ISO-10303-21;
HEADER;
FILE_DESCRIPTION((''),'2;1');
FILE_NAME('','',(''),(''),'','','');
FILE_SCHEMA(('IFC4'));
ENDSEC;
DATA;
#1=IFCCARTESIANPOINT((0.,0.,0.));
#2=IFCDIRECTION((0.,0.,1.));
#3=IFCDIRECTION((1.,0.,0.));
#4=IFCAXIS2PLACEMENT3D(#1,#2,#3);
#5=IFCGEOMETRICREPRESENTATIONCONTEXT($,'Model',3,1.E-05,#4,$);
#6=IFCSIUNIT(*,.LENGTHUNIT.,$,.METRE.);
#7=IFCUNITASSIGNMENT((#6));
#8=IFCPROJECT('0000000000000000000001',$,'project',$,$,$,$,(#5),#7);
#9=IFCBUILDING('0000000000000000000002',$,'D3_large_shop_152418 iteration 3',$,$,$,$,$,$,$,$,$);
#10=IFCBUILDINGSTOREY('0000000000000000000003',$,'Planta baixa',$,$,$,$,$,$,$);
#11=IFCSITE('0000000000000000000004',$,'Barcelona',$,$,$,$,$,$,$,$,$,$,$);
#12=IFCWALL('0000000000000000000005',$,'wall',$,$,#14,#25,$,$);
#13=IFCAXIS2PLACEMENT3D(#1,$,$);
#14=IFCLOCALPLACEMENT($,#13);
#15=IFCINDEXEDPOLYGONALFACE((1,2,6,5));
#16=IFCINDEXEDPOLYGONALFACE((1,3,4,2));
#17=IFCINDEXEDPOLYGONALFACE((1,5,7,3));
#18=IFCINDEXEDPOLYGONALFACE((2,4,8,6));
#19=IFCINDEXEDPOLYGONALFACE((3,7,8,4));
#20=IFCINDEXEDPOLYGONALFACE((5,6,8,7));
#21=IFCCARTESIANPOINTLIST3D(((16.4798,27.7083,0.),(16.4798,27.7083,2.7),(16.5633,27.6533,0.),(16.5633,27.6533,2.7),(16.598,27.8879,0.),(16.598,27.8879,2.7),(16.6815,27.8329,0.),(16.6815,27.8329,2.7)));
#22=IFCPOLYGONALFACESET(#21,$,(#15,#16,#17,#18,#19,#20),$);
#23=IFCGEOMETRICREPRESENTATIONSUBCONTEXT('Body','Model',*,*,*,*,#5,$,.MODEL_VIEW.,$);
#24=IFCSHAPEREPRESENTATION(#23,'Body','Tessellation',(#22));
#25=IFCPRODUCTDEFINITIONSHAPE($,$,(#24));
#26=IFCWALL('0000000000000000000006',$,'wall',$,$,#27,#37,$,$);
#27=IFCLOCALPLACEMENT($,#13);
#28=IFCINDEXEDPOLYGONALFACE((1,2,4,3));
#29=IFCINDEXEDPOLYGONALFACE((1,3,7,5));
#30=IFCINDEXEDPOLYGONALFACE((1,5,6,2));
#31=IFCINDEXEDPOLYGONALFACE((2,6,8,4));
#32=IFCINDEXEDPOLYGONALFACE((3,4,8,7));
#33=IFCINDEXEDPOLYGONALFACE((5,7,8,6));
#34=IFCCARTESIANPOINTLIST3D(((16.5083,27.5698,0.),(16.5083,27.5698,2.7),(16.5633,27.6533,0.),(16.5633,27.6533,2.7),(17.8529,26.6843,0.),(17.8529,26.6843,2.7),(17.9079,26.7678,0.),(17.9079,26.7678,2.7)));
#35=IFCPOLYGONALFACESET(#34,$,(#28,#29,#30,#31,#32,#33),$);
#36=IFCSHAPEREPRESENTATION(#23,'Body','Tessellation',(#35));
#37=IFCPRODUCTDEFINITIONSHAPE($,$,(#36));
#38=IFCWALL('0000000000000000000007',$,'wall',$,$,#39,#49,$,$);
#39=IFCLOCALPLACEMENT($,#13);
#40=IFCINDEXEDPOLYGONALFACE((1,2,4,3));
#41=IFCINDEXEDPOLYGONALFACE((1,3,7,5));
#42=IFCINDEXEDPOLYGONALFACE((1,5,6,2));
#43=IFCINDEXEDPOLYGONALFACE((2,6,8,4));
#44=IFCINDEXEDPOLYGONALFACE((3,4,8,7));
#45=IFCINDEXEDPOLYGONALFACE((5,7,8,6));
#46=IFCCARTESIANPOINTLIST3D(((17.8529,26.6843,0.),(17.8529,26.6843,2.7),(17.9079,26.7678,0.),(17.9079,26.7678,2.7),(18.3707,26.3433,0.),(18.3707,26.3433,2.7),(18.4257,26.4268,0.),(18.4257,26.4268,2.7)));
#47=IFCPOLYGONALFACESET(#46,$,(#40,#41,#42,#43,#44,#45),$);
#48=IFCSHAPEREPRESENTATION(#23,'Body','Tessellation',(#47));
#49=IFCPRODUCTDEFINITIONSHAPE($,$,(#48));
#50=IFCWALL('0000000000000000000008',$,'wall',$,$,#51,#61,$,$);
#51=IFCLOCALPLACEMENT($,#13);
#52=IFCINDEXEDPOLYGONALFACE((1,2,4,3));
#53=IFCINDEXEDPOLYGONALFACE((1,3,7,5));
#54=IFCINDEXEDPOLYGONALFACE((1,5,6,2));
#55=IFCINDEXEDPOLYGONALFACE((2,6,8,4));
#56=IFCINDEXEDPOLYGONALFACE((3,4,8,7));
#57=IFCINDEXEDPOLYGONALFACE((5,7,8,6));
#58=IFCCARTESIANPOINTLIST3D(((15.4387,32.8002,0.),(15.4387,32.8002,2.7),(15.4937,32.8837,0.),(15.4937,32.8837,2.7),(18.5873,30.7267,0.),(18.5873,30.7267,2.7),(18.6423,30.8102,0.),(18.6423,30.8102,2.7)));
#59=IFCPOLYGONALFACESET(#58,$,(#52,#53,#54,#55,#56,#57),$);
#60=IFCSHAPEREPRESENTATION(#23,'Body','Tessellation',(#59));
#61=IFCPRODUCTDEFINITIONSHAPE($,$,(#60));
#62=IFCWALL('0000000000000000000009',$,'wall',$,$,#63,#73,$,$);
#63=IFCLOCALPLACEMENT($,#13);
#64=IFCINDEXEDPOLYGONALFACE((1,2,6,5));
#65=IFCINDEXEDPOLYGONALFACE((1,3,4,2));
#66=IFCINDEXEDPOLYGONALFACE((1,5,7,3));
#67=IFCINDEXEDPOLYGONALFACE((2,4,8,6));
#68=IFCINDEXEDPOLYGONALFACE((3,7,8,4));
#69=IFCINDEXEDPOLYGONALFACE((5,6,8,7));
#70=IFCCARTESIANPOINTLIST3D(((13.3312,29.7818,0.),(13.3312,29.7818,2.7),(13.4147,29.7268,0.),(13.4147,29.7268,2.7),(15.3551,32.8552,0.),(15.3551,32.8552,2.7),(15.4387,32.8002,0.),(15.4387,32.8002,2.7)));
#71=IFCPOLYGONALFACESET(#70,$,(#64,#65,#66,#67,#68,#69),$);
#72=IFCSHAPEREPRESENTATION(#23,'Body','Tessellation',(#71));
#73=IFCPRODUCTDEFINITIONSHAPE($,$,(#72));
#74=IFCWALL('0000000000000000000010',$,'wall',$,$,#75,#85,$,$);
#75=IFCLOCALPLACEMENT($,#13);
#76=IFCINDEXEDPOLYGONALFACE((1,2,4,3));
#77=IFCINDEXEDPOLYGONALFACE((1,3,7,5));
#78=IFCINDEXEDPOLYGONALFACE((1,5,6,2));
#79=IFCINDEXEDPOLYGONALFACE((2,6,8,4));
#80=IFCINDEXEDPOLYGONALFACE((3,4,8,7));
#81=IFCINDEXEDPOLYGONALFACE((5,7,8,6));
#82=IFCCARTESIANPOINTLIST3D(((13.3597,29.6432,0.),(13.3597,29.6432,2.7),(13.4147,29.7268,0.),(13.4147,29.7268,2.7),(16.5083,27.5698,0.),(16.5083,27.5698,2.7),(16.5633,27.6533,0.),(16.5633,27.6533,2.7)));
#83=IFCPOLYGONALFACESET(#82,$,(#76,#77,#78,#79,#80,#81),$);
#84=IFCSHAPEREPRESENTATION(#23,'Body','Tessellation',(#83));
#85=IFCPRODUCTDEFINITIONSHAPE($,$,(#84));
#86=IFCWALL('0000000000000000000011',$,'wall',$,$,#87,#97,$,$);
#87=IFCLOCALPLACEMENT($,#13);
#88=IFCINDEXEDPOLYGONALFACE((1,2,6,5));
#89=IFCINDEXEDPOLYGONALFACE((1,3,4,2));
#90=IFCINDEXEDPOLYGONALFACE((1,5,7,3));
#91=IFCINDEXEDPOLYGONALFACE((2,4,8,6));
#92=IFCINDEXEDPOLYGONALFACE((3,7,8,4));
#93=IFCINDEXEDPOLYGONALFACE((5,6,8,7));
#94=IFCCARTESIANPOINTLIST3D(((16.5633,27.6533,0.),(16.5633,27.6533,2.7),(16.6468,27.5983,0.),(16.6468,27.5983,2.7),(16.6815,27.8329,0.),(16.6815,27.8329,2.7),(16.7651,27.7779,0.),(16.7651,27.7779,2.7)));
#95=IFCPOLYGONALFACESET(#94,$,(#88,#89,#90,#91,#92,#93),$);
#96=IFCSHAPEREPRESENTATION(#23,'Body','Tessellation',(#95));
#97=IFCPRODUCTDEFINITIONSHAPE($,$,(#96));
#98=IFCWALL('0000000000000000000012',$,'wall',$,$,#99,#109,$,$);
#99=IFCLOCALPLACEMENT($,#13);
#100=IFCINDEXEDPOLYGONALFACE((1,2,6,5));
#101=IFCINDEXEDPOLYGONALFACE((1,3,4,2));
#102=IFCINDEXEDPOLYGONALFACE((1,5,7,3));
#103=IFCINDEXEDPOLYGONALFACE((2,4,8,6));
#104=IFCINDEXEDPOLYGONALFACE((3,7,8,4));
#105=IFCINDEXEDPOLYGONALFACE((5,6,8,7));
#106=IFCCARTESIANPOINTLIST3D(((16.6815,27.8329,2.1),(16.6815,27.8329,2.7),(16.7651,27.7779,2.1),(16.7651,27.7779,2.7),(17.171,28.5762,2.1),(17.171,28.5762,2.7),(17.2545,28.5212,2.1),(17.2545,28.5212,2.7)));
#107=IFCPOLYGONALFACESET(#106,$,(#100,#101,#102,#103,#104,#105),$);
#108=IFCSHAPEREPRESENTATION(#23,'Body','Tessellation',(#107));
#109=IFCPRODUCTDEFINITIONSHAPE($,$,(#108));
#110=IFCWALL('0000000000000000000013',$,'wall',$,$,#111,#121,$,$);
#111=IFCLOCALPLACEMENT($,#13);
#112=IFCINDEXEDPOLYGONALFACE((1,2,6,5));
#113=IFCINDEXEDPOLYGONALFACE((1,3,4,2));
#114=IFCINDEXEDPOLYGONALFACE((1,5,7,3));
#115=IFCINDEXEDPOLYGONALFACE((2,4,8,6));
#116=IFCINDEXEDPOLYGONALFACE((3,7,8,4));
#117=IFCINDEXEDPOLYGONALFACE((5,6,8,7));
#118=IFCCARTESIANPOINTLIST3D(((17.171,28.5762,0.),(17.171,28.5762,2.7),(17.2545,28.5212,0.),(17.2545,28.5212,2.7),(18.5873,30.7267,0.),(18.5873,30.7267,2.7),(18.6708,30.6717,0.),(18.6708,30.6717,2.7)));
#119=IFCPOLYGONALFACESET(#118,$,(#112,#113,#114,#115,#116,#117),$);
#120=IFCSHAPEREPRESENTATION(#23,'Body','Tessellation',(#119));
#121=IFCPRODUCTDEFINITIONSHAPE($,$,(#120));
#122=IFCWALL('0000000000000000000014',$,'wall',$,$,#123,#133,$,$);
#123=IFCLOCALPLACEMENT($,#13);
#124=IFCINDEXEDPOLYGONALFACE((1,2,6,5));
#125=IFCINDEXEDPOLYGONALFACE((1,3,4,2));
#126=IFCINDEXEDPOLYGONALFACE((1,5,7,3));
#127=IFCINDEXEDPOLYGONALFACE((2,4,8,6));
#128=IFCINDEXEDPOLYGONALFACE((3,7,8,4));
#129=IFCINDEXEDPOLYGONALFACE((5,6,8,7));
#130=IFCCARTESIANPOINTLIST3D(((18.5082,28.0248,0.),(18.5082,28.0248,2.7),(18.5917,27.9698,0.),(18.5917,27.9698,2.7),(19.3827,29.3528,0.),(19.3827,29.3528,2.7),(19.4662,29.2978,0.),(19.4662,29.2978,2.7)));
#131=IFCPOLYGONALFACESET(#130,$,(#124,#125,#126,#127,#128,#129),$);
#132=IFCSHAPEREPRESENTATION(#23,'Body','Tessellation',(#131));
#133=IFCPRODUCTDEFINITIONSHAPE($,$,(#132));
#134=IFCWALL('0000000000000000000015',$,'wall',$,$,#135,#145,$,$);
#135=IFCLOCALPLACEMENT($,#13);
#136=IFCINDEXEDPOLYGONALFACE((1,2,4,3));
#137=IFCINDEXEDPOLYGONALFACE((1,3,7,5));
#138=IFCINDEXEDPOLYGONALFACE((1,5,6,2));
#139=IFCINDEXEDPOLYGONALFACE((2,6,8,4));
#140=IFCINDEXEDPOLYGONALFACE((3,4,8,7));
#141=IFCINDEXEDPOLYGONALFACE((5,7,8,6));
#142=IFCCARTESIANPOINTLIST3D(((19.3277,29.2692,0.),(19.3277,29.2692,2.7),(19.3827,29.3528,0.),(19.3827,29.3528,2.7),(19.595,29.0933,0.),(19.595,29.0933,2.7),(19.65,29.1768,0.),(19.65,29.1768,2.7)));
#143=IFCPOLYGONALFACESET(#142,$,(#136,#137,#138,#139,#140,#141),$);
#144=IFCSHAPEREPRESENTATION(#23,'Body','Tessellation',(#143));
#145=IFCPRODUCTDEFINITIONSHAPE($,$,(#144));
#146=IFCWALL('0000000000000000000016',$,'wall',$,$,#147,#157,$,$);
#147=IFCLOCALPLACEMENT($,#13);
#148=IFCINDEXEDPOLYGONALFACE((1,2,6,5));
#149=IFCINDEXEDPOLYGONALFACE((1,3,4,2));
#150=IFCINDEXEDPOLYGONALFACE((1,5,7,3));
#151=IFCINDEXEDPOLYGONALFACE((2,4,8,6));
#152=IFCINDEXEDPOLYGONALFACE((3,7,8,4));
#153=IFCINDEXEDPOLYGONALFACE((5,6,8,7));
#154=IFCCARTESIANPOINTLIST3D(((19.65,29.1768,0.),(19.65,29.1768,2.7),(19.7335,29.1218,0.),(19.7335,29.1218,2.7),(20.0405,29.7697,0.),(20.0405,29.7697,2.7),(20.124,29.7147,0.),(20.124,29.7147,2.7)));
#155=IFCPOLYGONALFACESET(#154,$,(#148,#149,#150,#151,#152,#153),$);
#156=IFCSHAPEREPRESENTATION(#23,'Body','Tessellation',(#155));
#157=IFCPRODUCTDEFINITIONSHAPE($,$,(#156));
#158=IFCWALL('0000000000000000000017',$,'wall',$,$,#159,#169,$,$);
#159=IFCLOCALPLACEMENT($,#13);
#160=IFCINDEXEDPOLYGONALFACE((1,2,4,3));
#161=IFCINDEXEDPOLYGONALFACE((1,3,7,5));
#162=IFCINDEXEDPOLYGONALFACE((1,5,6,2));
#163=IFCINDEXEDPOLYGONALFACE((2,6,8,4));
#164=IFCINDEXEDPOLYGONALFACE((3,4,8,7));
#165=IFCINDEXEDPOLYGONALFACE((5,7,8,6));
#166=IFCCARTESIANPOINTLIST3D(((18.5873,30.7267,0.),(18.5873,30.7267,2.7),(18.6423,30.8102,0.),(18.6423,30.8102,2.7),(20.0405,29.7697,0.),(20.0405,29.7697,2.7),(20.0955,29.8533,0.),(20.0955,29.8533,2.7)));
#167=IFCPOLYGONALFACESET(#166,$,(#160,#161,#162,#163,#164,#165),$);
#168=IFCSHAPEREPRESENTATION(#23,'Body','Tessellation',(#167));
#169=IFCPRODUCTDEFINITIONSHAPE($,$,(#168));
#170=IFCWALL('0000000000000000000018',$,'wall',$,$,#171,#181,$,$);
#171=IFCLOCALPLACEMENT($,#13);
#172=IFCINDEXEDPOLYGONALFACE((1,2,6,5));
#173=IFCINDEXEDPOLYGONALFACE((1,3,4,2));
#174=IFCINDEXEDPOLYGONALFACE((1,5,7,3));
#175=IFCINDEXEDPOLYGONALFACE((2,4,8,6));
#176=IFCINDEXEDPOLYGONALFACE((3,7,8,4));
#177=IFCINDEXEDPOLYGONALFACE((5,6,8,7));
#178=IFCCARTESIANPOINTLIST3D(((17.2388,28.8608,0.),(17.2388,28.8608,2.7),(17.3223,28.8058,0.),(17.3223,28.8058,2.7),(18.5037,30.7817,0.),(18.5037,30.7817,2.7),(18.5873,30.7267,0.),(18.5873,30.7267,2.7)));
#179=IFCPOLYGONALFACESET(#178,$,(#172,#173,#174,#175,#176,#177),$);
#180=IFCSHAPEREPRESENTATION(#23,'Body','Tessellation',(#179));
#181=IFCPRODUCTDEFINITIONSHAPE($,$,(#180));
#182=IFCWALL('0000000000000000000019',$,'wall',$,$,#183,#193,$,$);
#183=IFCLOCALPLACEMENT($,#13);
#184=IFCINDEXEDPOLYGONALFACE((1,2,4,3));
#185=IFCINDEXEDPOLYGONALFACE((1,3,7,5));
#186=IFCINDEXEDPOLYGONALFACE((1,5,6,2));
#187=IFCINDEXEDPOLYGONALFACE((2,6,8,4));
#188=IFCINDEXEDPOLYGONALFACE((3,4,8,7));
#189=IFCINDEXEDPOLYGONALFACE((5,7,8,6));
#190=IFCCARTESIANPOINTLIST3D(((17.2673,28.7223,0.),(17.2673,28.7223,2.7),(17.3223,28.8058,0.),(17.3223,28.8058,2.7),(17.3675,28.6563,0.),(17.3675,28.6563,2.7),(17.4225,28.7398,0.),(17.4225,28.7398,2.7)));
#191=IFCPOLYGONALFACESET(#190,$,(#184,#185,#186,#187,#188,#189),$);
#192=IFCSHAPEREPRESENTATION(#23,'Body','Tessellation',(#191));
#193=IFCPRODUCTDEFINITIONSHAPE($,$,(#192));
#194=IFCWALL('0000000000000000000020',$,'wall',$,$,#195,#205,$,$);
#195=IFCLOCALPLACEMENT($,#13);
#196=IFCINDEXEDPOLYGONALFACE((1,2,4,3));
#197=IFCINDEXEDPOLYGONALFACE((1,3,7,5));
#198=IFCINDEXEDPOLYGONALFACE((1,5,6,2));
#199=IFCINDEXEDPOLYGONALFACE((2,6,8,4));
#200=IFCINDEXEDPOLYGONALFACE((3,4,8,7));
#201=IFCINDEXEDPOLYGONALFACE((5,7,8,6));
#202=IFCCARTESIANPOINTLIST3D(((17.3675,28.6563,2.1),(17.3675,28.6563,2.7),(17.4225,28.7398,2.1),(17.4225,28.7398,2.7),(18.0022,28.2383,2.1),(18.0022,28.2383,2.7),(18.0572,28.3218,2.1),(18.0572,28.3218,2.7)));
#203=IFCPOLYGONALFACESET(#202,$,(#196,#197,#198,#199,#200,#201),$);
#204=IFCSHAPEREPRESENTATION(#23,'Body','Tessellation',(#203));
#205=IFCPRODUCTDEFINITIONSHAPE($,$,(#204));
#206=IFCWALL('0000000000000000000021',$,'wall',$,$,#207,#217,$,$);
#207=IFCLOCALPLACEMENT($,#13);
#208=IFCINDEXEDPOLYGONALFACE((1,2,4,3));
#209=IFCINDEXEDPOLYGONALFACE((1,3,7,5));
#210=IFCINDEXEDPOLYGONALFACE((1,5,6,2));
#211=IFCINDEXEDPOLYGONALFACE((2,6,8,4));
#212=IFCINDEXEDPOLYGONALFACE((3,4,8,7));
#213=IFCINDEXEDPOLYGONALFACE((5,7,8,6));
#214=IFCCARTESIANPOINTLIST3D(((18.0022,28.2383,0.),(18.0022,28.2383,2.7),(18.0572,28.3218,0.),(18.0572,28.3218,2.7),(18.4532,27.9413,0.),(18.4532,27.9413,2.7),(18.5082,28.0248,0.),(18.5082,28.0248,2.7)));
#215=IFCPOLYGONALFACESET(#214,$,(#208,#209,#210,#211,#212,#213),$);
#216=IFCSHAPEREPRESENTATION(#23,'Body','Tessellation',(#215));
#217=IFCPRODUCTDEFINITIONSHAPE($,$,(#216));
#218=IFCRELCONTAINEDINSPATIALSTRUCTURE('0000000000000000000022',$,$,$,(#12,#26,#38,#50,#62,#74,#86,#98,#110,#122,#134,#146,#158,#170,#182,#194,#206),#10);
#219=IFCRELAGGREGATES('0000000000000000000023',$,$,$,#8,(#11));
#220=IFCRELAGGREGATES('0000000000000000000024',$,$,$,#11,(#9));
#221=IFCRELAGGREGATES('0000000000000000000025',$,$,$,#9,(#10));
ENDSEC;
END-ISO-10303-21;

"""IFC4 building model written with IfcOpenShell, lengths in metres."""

from ifc_helpers import new_model, si_unit, frame, origin, origin_with_axes, place, context, subcontext, project, spatial, polyline, outline, extrude, element, save


model = new_model("IFC4")

# Units and contexts
model_context = context("Model", 3, precision=1e-05, world=origin_with_axes())
body_context = subcontext(model_context, "Body", "Model", "MODEL_VIEW")
ifc_project = project(units=[si_unit("LENGTHUNIT", "METRE")], contexts=[model_context])

# Site, building, storey
site = spatial("IfcSite", under=ifc_project, Name="Barcelona")
building = spatial("IfcBuilding", under=site, Name="D3_large_shop_152418 iteration 3")
storey = spatial("IfcBuildingStorey", under=building, Name="Planta baixa")

# Walls
wall_1_placement = place(None, origin_with_axes())
element("IfcWall", 1, at=wall_1_placement, inside=storey, Name="wall", context=body_context, shape_type="SweptSolid", body=[
    extrude(outline(polyline([(16.6815, 27.8329), (16.5633, 27.6533), (16.4798, 27.7083), (16.598, 27.8879), (16.6815, 27.8329)])), origin(), (0.0, 0.0, 1.0), 2.7),
])
wall_2_placement = place(None, origin_with_axes())
element("IfcWall", 2, at=wall_2_placement, inside=storey, Name="wall", context=body_context, shape_type="SweptSolid", body=[
    extrude(outline(polyline([(16.5633, 27.6533), (17.9079, 26.7678), (17.8529, 26.6843), (16.5083, 27.5698), (16.5633, 27.6533)])), origin(), (0.0, 0.0, 1.0), 2.7),
])
wall_3_placement = place(None, origin_with_axes())
element("IfcWall", 3, at=wall_3_placement, inside=storey, Name="wall", context=body_context, shape_type="SweptSolid", body=[
    extrude(outline(polyline([(17.9079, 26.7678), (18.4257, 26.4268), (18.3707, 26.3433), (17.8529, 26.6843), (17.9079, 26.7678)])), origin(), (0.0, 0.0, 1.0), 2.7),
])
wall_4_placement = place(None, origin_with_axes())
element("IfcWall", 4, at=wall_4_placement, inside=storey, Name="wall", context=body_context, shape_type="SweptSolid", body=[
    extrude(outline(polyline([(18.5873, 30.7267), (15.4387, 32.8002), (15.4937, 32.8837), (18.6423, 30.8102), (18.5873, 30.7267)])), origin(), (0.0, 0.0, 1.0), 2.7),
])
wall_5_placement = place(None, origin_with_axes())
element("IfcWall", 5, at=wall_5_placement, inside=storey, Name="wall", context=body_context, shape_type="SweptSolid", body=[
    extrude(outline(polyline([(15.4387, 32.8002), (13.4147, 29.7268), (13.3312, 29.7818), (15.3551, 32.8552), (15.4387, 32.8002)])), origin(), (0.0, 0.0, 1.0), 2.7),
])
wall_6_placement = place(None, origin_with_axes())
element("IfcWall", 6, at=wall_6_placement, inside=storey, Name="wall", context=body_context, shape_type="SweptSolid", body=[
    extrude(outline(polyline([(13.4147, 29.7268), (16.5633, 27.6533), (16.5083, 27.5698), (13.3597, 29.6432), (13.4147, 29.7268)])), origin(), (0.0, 0.0, 1.0), 2.7),
])
wall_7_placement = place(None, origin_with_axes())
element("IfcWall", 7, at=wall_7_placement, inside=storey, Name="wall", context=body_context, shape_type="SweptSolid", body=[
    extrude(outline(polyline([(16.5633, 27.6533), (16.6815, 27.8329), (16.7651, 27.7779), (16.6468, 27.5983), (16.5633, 27.6533)])), origin(), (0.0, 0.0, 1.0), 2.7),
])
wall_8_placement = place(None, origin_with_axes())
element("IfcWall", 8, at=wall_8_placement, inside=storey, Name="wall", context=body_context, shape_type="SweptSolid", body=[
    extrude(outline(polyline([(16.6815, 27.8329), (17.171, 28.5762), (17.2545, 28.5212), (16.7651, 27.7779), (16.6815, 27.8329)])), frame((0.0, 0.0, 2.1)), (0.0, 0.0, 1.0), 0.6),
])
wall_9_placement = place(None, origin_with_axes())
element("IfcWall", 9, at=wall_9_placement, inside=storey, Name="wall", context=body_context, shape_type="SweptSolid", body=[
    extrude(outline(polyline([(17.171, 28.5762), (18.5873, 30.7267), (18.6708, 30.6717), (17.2545, 28.5212), (17.171, 28.5762)])), origin(), (0.0, 0.0, 1.0), 2.7),
])
wall_10_placement = place(None, origin_with_axes())
element("IfcWall", 10, at=wall_10_placement, inside=storey, Name="wall", context=body_context, shape_type="SweptSolid", body=[
    extrude(outline(polyline([(18.5082, 28.0248), (19.3827, 29.3528), (19.4662, 29.2978), (18.5917, 27.9698), (18.5082, 28.0248)])), origin(), (0.0, 0.0, 1.0), 2.7),
])
wall_11_placement = place(None, origin_with_axes())
element("IfcWall", 11, at=wall_11_placement, inside=storey, Name="wall", context=body_context, shape_type="SweptSolid", body=[
    extrude(outline(polyline([(19.3827, 29.3528), (19.65, 29.1768), (19.595, 29.0933), (19.3277, 29.2692), (19.3827, 29.3528)])), origin(), (0.0, 0.0, 1.0), 2.7),
])
wall_12_placement = place(None, origin_with_axes())
element("IfcWall", 12, at=wall_12_placement, inside=storey, Name="wall", context=body_context, shape_type="SweptSolid", body=[
    extrude(outline(polyline([(19.65, 29.1768), (20.0405, 29.7697), (20.124, 29.7147), (19.7335, 29.1218), (19.65, 29.1768)])), origin(), (0.0, 0.0, 1.0), 2.7),
])
wall_13_placement = place(None, origin_with_axes())
element("IfcWall", 13, at=wall_13_placement, inside=storey, Name="wall", context=body_context, shape_type="SweptSolid", body=[
    extrude(outline(polyline([(20.0405, 29.7697), (18.5873, 30.7267), (18.6423, 30.8102), (20.0955, 29.8533), (20.0405, 29.7697)])), origin(), (0.0, 0.0, 1.0), 2.7),
])
wall_14_placement = place(None, origin_with_axes())
element("IfcWall", 14, at=wall_14_placement, inside=storey, Name="wall", context=body_context, shape_type="SweptSolid", body=[
    extrude(outline(polyline([(18.5873, 30.7267), (17.3223, 28.8058), (17.2388, 28.8608), (18.5037, 30.7817), (18.5873, 30.7267)])), origin(), (0.0, 0.0, 1.0), 2.7),
])
wall_15_placement = place(None, origin_with_axes())
element("IfcWall", 15, at=wall_15_placement, inside=storey, Name="wall", context=body_context, shape_type="SweptSolid", body=[
    extrude(outline(polyline([(17.3223, 28.8058), (17.4225, 28.7398), (17.3675, 28.6563), (17.2673, 28.7223), (17.3223, 28.8058)])), origin(), (0.0, 0.0, 1.0), 2.7),
])
wall_16_placement = place(None, origin_with_axes())
element("IfcWall", 16, at=wall_16_placement, inside=storey, Name="wall", context=body_context, shape_type="SweptSolid", body=[
    extrude(outline(polyline([(17.4225, 28.7398), (18.0572, 28.3218), (18.0022, 28.2383), (17.3675, 28.6563), (17.4225, 28.7398)])), frame((0.0, 0.0, 2.1)), (0.0, 0.0, 1.0), 0.6),
])
wall_17_placement = place(None, origin_with_axes())
element("IfcWall", 17, at=wall_17_placement, inside=storey, Name="wall", context=body_context, shape_type="SweptSolid", body=[
    extrude(outline(polyline([(18.0572, 28.3218), (18.5082, 28.0248), (18.4532, 27.9413), (18.0022, 28.2383), (18.0572, 28.3218)])), origin(), (0.0, 0.0, 1.0), 2.7),
])

save(model, "model.ifc")
